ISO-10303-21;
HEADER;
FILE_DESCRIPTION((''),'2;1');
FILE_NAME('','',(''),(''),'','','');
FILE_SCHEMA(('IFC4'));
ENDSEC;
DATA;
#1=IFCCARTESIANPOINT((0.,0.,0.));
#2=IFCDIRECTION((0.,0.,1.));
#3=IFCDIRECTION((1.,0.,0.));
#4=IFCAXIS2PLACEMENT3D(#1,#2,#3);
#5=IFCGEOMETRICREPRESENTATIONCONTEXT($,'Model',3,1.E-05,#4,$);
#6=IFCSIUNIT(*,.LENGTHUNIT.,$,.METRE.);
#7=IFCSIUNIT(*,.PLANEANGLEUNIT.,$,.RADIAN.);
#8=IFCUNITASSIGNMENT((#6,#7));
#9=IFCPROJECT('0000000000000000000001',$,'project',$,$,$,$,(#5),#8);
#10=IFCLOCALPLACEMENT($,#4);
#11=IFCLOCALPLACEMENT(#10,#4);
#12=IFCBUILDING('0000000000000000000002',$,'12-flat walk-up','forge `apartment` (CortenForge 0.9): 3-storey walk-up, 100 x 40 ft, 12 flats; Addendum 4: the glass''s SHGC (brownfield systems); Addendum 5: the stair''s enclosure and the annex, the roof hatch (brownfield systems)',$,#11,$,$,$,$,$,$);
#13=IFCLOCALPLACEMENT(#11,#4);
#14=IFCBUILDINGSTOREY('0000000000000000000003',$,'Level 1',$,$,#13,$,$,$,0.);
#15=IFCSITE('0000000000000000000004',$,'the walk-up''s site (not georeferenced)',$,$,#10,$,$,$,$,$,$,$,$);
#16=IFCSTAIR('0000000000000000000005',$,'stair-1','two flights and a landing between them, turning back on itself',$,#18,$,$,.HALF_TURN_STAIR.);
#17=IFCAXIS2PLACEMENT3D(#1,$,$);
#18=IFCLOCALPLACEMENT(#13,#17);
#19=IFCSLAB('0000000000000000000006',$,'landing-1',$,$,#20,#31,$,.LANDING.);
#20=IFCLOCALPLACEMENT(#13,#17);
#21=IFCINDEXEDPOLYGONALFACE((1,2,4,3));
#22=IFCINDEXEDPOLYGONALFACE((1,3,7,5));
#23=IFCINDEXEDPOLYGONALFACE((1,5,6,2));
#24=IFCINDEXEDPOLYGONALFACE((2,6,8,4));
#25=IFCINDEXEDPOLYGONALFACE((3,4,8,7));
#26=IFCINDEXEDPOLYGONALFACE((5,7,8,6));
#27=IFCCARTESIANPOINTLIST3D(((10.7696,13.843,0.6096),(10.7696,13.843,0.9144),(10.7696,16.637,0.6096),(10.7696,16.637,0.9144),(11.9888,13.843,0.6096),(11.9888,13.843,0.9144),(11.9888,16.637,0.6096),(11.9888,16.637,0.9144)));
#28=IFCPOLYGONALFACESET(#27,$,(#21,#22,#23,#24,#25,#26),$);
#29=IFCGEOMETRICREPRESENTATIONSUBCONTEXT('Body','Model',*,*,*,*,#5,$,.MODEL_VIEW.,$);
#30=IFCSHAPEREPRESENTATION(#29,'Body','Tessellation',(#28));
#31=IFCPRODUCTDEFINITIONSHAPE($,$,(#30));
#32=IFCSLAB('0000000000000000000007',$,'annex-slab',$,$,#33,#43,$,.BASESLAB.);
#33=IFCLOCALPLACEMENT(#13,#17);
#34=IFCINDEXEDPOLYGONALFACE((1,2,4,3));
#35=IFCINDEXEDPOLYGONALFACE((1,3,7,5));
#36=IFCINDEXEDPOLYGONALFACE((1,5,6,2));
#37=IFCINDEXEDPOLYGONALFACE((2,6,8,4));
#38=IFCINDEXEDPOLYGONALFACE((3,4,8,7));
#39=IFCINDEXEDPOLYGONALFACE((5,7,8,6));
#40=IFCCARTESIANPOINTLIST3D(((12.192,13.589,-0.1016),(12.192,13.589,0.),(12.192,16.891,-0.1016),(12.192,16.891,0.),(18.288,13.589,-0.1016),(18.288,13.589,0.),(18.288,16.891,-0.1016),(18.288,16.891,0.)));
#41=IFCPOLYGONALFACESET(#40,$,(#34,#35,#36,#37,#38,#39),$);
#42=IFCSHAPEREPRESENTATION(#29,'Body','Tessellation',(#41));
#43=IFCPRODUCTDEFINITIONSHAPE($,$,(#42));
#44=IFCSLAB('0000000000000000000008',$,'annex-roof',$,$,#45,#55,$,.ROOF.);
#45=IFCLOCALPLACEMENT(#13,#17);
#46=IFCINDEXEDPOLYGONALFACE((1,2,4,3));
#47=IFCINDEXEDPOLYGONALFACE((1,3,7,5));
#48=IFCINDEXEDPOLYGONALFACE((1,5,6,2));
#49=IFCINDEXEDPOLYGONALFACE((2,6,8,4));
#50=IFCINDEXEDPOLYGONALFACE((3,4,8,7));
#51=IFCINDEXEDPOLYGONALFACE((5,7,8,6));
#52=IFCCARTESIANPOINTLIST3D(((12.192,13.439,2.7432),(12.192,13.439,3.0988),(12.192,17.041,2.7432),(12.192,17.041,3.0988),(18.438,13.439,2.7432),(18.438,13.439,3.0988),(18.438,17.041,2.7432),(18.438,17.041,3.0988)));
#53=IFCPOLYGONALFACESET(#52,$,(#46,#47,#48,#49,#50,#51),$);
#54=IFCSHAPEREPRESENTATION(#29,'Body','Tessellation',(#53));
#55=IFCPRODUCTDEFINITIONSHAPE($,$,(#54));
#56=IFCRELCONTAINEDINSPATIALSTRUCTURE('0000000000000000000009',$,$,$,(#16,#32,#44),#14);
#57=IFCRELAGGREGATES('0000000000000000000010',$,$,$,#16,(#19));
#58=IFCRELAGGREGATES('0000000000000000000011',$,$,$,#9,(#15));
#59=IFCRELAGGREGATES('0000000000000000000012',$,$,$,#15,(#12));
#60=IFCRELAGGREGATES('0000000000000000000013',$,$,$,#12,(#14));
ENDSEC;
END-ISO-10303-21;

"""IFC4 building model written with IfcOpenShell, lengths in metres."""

from ifc_helpers import new_model, si_unit, frame, frame_2d, origin, origin_with_axes, place, context, subcontext, project, spatial, rectangle, extrude, element, aggregate, save


model = new_model("IFC4")

# Units and contexts
model_context = context("Model", 3, precision=1e-05, world=origin_with_axes())
body_context = subcontext(model_context, "Body", "Model", "MODEL_VIEW")
ifc_project = project(units=[si_unit("LENGTHUNIT", "METRE"), si_unit("PLANEANGLEUNIT", "RADIAN")], contexts=[model_context])

# Site, building, storey
site_placement = place(None, origin_with_axes())
site = spatial("IfcSite", under=ifc_project, at=site_placement, Name="the walk-up's site (not georeferenced)")
building_placement = place(site_placement, origin_with_axes())
building = spatial("IfcBuilding", under=site, at=building_placement, Name="12-flat walk-up", Description="forge `apartment` (CortenForge 0.9): 3-storey walk-up, 100 x 40 ft, 12 flats; Addendum 4: the glass's SHGC (brownfield systems); Addendum 5: the stair's enclosure and the annex, the roof hatch (brownfield systems)")
storey_placement = place(building_placement, origin_with_axes())
storey = spatial("IfcBuildingStorey", under=building, at=storey_placement, Name="Level 1", Elevation=0.0)

# Stair, slab
stair_placement = place(storey_placement, origin_with_axes())
stair = element("IfcStair", 1, at=stair_placement, inside=storey, Name="stair-1", Description="two flights and a landing between them, turning back on itself", PredefinedType="HALF_TURN_STAIR")
slab_1_placement = place(stair_placement, frame((10.7696, 13.843, 0.6096), z_axis=(0.0, 0.0, 1.0), x_axis=(1.0, 0.0, 0.0)))
slab_1 = element("IfcSlab", 2, at=slab_1_placement, Name="landing-1", PredefinedType="LANDING", context=body_context, shape_type="SweptSolid", body=[
    extrude(rectangle(XDim=1.2192, YDim=2.794, at=frame_2d((0.6096, 1.397))), origin(), (0.0, 0.0, 1.0), 0.3048),
])
aggregate(stair, [slab_1])

# Slabs
slab_2_placement = place(storey_placement, frame((12.192, 13.589, -0.1016), z_axis=(0.0, 0.0, 1.0), x_axis=(1.0, 0.0, 0.0)))
element("IfcSlab", 3, at=slab_2_placement, inside=storey, Name="annex-slab", PredefinedType="BASESLAB", context=body_context, shape_type="SweptSolid", body=[
    extrude(rectangle(XDim=6.096, YDim=3.302, at=frame_2d((3.048, 1.651))), origin(), (0.0, 0.0, 1.0), 0.1016),
])
slab_3_placement = place(storey_placement, frame((12.192, 13.439, 2.7432), z_axis=(0.0, 0.0, 1.0), x_axis=(1.0, 0.0, 0.0)))
element("IfcSlab", 4, at=slab_3_placement, inside=storey, Name="annex-roof", PredefinedType="ROOF", context=body_context, shape_type="SweptSolid", body=[
    extrude(rectangle(XDim=6.246, YDim=3.602, at=frame_2d((3.123, 1.801))), origin(), (0.0, 0.0, 1.0), 0.3556),
])

save(model, "model.ifc")
